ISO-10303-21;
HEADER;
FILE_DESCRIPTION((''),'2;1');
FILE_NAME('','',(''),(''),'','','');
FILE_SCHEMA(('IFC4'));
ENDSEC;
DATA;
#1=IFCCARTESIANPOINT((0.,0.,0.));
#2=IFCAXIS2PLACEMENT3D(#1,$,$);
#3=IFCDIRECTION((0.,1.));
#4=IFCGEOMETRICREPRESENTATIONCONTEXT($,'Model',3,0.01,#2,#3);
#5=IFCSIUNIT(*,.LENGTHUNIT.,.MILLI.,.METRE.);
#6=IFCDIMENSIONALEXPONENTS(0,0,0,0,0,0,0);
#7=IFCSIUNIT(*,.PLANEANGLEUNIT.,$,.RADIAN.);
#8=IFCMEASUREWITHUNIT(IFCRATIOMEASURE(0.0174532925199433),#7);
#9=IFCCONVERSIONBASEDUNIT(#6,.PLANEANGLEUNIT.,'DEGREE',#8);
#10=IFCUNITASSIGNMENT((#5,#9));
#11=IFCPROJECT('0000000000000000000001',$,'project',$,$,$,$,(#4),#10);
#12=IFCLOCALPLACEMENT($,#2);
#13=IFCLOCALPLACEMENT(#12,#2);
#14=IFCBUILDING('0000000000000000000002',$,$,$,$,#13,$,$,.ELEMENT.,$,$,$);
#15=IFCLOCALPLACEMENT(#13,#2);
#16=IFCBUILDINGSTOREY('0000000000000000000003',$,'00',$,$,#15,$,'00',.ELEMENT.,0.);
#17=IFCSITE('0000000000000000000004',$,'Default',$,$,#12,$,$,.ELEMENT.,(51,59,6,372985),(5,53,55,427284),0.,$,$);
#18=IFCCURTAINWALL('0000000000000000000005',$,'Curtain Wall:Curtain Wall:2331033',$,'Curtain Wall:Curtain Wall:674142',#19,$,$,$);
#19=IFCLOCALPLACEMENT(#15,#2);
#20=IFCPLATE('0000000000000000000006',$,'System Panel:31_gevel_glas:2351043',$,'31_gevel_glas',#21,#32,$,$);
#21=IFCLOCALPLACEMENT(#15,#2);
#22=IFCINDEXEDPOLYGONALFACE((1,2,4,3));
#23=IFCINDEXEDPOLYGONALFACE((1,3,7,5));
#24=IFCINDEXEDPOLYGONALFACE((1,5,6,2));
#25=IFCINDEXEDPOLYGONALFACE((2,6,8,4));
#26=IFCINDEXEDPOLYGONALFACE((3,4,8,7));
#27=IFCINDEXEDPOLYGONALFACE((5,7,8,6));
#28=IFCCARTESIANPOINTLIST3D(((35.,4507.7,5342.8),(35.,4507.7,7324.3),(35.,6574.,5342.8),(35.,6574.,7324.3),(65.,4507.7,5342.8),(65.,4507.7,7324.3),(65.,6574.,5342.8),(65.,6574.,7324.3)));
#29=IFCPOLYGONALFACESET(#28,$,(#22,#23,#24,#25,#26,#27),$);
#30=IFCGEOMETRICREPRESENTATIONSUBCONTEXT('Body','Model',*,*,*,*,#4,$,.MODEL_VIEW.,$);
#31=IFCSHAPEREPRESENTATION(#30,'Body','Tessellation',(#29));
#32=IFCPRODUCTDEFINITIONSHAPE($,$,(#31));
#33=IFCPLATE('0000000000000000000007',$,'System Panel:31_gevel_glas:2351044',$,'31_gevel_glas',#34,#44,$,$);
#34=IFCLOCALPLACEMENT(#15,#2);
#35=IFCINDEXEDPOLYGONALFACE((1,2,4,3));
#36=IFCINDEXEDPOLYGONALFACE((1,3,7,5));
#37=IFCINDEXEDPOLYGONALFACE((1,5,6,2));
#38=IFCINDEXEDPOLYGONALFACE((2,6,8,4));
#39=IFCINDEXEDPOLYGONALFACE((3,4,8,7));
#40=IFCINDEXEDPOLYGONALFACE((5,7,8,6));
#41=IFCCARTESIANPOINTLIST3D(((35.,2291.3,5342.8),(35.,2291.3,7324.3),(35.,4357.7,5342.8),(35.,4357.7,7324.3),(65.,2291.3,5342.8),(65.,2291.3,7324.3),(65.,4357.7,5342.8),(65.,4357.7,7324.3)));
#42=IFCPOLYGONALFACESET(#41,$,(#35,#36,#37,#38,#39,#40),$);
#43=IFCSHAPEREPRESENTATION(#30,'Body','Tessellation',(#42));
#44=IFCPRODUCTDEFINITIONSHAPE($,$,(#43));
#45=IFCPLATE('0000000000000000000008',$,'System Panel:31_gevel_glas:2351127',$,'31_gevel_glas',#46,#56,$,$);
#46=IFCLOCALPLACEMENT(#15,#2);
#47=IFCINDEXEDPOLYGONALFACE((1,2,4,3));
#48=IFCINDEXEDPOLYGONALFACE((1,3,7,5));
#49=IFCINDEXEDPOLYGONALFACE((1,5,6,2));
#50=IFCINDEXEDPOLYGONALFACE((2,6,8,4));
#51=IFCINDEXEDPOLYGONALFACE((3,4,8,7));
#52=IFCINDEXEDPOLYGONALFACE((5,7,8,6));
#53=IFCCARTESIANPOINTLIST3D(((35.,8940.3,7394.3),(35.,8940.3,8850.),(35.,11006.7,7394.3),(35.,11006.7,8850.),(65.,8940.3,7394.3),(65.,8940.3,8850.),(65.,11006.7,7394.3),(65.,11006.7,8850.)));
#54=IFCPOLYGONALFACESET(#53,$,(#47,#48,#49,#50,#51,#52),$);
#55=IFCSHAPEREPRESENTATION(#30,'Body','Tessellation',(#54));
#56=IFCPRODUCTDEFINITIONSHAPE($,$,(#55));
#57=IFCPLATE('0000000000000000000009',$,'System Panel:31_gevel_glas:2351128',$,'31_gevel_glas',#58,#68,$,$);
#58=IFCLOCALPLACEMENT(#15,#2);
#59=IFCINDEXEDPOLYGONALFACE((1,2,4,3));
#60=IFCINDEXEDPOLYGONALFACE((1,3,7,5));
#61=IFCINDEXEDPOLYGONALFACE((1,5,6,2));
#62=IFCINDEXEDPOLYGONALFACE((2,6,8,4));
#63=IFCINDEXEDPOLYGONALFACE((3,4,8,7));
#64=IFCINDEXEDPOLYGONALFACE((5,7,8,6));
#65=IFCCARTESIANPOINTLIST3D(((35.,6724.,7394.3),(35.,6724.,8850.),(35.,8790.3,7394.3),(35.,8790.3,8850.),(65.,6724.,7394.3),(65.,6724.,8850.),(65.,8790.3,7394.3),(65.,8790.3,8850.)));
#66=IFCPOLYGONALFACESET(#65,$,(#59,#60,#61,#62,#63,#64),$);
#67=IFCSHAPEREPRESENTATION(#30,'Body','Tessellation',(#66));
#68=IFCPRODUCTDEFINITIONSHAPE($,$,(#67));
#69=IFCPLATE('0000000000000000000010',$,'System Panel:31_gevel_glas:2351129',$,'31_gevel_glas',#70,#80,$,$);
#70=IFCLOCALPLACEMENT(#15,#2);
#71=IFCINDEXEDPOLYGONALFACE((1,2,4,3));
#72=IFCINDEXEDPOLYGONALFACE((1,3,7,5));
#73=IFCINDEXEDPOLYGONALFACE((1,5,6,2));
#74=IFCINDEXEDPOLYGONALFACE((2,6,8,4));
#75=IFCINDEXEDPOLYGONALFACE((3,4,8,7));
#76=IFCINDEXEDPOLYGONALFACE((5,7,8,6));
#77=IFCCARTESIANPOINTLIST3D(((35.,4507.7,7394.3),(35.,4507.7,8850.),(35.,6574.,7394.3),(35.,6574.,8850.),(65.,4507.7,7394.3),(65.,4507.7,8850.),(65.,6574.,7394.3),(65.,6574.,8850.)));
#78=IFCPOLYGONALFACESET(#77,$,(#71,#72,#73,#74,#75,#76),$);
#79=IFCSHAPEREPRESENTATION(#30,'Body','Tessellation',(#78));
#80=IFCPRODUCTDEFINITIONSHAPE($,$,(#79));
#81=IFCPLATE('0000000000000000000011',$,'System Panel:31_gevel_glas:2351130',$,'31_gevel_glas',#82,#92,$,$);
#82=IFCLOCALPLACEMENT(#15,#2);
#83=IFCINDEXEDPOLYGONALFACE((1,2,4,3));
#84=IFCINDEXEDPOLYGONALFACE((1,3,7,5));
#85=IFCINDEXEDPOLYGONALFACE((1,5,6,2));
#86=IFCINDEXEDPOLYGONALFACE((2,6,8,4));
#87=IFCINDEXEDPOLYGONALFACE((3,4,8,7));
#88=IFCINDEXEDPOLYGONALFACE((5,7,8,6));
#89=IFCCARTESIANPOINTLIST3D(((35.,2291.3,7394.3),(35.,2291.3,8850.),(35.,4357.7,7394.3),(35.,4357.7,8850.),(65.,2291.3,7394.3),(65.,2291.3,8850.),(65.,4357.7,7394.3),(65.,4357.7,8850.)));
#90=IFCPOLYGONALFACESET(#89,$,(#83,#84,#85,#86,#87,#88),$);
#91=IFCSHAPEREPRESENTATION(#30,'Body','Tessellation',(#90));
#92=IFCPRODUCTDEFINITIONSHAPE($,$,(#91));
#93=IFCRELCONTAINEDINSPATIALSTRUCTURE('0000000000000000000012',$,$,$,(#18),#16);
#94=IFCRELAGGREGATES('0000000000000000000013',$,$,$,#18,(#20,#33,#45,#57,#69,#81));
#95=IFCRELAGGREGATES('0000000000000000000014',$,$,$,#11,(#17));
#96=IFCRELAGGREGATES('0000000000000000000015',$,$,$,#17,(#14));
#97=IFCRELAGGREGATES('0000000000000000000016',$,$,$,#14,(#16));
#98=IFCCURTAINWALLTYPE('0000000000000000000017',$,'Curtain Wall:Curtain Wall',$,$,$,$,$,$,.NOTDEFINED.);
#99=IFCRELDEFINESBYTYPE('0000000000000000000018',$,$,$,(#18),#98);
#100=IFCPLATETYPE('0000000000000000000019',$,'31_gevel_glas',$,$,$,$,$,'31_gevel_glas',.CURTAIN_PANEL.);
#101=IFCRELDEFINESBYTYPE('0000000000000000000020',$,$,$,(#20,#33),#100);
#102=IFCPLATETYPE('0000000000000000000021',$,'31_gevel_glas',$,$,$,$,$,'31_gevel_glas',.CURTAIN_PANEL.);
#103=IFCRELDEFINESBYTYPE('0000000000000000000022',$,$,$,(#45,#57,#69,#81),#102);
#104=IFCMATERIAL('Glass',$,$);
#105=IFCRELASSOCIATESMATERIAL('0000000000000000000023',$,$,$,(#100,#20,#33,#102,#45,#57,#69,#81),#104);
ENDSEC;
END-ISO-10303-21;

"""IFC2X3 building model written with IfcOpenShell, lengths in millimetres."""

from ifc_helpers import new_model, entity, si_unit, converted_unit, direction, frame, origin, origin_2d_with_axis, place, context, subcontext, project, spatial, rectangle, extrude, source, transform, mapped, material, type_object, type_shapes, element, aggregate, save


model = new_model("IFC2X3")

# Units and contexts
model_context = context("Model", 3, precision=0.01, world=origin(), true_north=direction((0.0, 1.0)))
body_context = subcontext(model_context, "Body", "Model", "MODEL_VIEW")
ifc_project = project(units=[si_unit("LENGTHUNIT", "METRE", prefix="MILLI"), converted_unit("PLANEANGLEUNIT", "DEGREE", entity("IfcRatioMeasure", 0.0174532925199433), si_unit("PLANEANGLEUNIT", "RADIAN"), dimensions=[0, 0, 0, 0, 0, 0, 0])], contexts=[model_context])

# Site, building, storey
site_placement = place(None, origin())
site = spatial("IfcSite", under=ifc_project, at=site_placement, Name="Default", CompositionType="ELEMENT", RefLatitude=(51, 59, 6, 372985), RefLongitude=(5, 53, 55, 427284), RefElevation=0.0)
building_placement = place(site_placement, origin())
building = spatial("IfcBuilding", under=site, at=building_placement, CompositionType="ELEMENT")
storey_placement = place(building_placement, origin())
storey = spatial("IfcBuildingStorey", under=building, at=storey_placement, Name="00", LongName="00", CompositionType="ELEMENT", Elevation=0.0)

# Curtain wall, plates
curtain_wall_type = type_object("IfcCurtainWallType", Name="Curtain Wall:Curtain Wall", PredefinedType="NOTDEFINED")
curtain_wall_placement = place(storey_placement, origin())
curtain_wall = element("IfcCurtainWall", 1, at=curtain_wall_placement, inside=storey, type_object=curtain_wall_type, Name="Curtain Wall:Curtain Wall:2331033", ObjectType="Curtain Wall:Curtain Wall:674142")
ifc_material_1 = material(Name="Glass")
plate_type_1 = type_object("IfcPlateType", Name="31_gevel_glas", ElementType="31_gevel_glas", PredefinedType="CURTAIN_PANEL", material=ifc_material_1)
shared_shape_1 = source(origin(), body_context, "Body", "SweptSolid", [
    extrude(rectangle(XDim=30.0, YDim=2066.3, at=origin_2d_with_axis()), frame((0.0, 50.0, 0.0), z_axis=(0.0, 0.0, 1.0), x_axis=(0.0, 1.0, 0.0)), (0.0, 0.0, 1.0), 1981.5),
])
type_shapes(plate_type_1, [shared_shape_1])
plate_1_placement = place(curtain_wall_placement, frame((0.0, 5540.8, 5342.8), z_axis=(0.0, 0.0, 1.0), x_axis=(0.0, -1.0, 0.0)))
plate_1 = element("IfcPlate", 2, at=plate_1_placement, type_object=plate_type_1, material=ifc_material_1, Name="System Panel:31_gevel_glas:2351043", ObjectType="31_gevel_glas", context=body_context, shape_type="MappedRepresentation", body=[
    mapped(shared_shape_1, transform((0.0, 0.0, 0.0), scale=1.0)),
])
plate_2_placement = place(curtain_wall_placement, frame((0.0, 3324.5, 5342.8), z_axis=(0.0, 0.0, 1.0), x_axis=(0.0, -1.0, 0.0)))
plate_2 = element("IfcPlate", 3, at=plate_2_placement, type_object=plate_type_1, material=ifc_material_1, Name="System Panel:31_gevel_glas:2351044", ObjectType="31_gevel_glas", context=body_context, shape_type="MappedRepresentation", body=[
    mapped(shared_shape_1, transform((0.0, 0.0, 0.0), scale=1.0)),
])
plate_type_2 = type_object("IfcPlateType", Name="31_gevel_glas", ElementType="31_gevel_glas", PredefinedType="CURTAIN_PANEL", material=ifc_material_1)
shared_shape_2 = source(origin(), body_context, "Body", "SweptSolid", [
    extrude(rectangle(XDim=30.0, YDim=2066.3, at=origin_2d_with_axis()), frame((0.0, 50.0, 0.0), z_axis=(0.0, 0.0, 1.0), x_axis=(0.0, 1.0, 0.0)), (0.0, 0.0, 1.0), 1455.7),
])
type_shapes(plate_type_2, [shared_shape_2])
plate_3_placement = place(curtain_wall_placement, frame((0.0, 9973.5, 7394.3), z_axis=(0.0, 0.0, 1.0), x_axis=(0.0, -1.0, 0.0)))
plate_3 = element("IfcPlate", 4, at=plate_3_placement, type_object=plate_type_2, material=ifc_material_1, Name="System Panel:31_gevel_glas:2351127", ObjectType="31_gevel_glas", context=body_context, shape_type="MappedRepresentation", body=[
    mapped(shared_shape_2, transform((0.0, 0.0, 0.0), scale=1.0)),
])
plate_4_placement = place(curtain_wall_placement, frame((0.0, 7757.2, 7394.3), z_axis=(0.0, 0.0, 1.0), x_axis=(0.0, -1.0, 0.0)))
plate_4 = element("IfcPlate", 5, at=plate_4_placement, type_object=plate_type_2, material=ifc_material_1, Name="System Panel:31_gevel_glas:2351128", ObjectType="31_gevel_glas", context=body_context, shape_type="MappedRepresentation", body=[
    mapped(shared_shape_2, transform((0.0, 0.0, 0.0), scale=1.0)),
])
plate_5_placement = place(curtain_wall_placement, frame((0.0, 5540.8, 7394.3), z_axis=(0.0, 0.0, 1.0), x_axis=(0.0, -1.0, 0.0)))
plate_5 = element("IfcPlate", 6, at=plate_5_placement, type_object=plate_type_2, material=ifc_material_1, Name="System Panel:31_gevel_glas:2351129", ObjectType="31_gevel_glas", context=body_context, shape_type="MappedRepresentation", body=[
    mapped(shared_shape_2, transform((0.0, 0.0, 0.0), scale=1.0)),
])
plate_6_placement = place(curtain_wall_placement, frame((0.0, 3324.5, 7394.3), z_axis=(0.0, 0.0, 1.0), x_axis=(0.0, -1.0, 0.0)))
plate_6 = element("IfcPlate", 7, at=plate_6_placement, type_object=plate_type_2, material=ifc_material_1, Name="System Panel:31_gevel_glas:2351130", ObjectType="31_gevel_glas", context=body_context, shape_type="MappedRepresentation", body=[
    mapped(shared_shape_2, transform((0.0, 0.0, 0.0), scale=1.0)),
])
aggregate(curtain_wall, [plate_1, plate_2, plate_3, plate_4, plate_5, plate_6])

save(model, "model.ifc")
